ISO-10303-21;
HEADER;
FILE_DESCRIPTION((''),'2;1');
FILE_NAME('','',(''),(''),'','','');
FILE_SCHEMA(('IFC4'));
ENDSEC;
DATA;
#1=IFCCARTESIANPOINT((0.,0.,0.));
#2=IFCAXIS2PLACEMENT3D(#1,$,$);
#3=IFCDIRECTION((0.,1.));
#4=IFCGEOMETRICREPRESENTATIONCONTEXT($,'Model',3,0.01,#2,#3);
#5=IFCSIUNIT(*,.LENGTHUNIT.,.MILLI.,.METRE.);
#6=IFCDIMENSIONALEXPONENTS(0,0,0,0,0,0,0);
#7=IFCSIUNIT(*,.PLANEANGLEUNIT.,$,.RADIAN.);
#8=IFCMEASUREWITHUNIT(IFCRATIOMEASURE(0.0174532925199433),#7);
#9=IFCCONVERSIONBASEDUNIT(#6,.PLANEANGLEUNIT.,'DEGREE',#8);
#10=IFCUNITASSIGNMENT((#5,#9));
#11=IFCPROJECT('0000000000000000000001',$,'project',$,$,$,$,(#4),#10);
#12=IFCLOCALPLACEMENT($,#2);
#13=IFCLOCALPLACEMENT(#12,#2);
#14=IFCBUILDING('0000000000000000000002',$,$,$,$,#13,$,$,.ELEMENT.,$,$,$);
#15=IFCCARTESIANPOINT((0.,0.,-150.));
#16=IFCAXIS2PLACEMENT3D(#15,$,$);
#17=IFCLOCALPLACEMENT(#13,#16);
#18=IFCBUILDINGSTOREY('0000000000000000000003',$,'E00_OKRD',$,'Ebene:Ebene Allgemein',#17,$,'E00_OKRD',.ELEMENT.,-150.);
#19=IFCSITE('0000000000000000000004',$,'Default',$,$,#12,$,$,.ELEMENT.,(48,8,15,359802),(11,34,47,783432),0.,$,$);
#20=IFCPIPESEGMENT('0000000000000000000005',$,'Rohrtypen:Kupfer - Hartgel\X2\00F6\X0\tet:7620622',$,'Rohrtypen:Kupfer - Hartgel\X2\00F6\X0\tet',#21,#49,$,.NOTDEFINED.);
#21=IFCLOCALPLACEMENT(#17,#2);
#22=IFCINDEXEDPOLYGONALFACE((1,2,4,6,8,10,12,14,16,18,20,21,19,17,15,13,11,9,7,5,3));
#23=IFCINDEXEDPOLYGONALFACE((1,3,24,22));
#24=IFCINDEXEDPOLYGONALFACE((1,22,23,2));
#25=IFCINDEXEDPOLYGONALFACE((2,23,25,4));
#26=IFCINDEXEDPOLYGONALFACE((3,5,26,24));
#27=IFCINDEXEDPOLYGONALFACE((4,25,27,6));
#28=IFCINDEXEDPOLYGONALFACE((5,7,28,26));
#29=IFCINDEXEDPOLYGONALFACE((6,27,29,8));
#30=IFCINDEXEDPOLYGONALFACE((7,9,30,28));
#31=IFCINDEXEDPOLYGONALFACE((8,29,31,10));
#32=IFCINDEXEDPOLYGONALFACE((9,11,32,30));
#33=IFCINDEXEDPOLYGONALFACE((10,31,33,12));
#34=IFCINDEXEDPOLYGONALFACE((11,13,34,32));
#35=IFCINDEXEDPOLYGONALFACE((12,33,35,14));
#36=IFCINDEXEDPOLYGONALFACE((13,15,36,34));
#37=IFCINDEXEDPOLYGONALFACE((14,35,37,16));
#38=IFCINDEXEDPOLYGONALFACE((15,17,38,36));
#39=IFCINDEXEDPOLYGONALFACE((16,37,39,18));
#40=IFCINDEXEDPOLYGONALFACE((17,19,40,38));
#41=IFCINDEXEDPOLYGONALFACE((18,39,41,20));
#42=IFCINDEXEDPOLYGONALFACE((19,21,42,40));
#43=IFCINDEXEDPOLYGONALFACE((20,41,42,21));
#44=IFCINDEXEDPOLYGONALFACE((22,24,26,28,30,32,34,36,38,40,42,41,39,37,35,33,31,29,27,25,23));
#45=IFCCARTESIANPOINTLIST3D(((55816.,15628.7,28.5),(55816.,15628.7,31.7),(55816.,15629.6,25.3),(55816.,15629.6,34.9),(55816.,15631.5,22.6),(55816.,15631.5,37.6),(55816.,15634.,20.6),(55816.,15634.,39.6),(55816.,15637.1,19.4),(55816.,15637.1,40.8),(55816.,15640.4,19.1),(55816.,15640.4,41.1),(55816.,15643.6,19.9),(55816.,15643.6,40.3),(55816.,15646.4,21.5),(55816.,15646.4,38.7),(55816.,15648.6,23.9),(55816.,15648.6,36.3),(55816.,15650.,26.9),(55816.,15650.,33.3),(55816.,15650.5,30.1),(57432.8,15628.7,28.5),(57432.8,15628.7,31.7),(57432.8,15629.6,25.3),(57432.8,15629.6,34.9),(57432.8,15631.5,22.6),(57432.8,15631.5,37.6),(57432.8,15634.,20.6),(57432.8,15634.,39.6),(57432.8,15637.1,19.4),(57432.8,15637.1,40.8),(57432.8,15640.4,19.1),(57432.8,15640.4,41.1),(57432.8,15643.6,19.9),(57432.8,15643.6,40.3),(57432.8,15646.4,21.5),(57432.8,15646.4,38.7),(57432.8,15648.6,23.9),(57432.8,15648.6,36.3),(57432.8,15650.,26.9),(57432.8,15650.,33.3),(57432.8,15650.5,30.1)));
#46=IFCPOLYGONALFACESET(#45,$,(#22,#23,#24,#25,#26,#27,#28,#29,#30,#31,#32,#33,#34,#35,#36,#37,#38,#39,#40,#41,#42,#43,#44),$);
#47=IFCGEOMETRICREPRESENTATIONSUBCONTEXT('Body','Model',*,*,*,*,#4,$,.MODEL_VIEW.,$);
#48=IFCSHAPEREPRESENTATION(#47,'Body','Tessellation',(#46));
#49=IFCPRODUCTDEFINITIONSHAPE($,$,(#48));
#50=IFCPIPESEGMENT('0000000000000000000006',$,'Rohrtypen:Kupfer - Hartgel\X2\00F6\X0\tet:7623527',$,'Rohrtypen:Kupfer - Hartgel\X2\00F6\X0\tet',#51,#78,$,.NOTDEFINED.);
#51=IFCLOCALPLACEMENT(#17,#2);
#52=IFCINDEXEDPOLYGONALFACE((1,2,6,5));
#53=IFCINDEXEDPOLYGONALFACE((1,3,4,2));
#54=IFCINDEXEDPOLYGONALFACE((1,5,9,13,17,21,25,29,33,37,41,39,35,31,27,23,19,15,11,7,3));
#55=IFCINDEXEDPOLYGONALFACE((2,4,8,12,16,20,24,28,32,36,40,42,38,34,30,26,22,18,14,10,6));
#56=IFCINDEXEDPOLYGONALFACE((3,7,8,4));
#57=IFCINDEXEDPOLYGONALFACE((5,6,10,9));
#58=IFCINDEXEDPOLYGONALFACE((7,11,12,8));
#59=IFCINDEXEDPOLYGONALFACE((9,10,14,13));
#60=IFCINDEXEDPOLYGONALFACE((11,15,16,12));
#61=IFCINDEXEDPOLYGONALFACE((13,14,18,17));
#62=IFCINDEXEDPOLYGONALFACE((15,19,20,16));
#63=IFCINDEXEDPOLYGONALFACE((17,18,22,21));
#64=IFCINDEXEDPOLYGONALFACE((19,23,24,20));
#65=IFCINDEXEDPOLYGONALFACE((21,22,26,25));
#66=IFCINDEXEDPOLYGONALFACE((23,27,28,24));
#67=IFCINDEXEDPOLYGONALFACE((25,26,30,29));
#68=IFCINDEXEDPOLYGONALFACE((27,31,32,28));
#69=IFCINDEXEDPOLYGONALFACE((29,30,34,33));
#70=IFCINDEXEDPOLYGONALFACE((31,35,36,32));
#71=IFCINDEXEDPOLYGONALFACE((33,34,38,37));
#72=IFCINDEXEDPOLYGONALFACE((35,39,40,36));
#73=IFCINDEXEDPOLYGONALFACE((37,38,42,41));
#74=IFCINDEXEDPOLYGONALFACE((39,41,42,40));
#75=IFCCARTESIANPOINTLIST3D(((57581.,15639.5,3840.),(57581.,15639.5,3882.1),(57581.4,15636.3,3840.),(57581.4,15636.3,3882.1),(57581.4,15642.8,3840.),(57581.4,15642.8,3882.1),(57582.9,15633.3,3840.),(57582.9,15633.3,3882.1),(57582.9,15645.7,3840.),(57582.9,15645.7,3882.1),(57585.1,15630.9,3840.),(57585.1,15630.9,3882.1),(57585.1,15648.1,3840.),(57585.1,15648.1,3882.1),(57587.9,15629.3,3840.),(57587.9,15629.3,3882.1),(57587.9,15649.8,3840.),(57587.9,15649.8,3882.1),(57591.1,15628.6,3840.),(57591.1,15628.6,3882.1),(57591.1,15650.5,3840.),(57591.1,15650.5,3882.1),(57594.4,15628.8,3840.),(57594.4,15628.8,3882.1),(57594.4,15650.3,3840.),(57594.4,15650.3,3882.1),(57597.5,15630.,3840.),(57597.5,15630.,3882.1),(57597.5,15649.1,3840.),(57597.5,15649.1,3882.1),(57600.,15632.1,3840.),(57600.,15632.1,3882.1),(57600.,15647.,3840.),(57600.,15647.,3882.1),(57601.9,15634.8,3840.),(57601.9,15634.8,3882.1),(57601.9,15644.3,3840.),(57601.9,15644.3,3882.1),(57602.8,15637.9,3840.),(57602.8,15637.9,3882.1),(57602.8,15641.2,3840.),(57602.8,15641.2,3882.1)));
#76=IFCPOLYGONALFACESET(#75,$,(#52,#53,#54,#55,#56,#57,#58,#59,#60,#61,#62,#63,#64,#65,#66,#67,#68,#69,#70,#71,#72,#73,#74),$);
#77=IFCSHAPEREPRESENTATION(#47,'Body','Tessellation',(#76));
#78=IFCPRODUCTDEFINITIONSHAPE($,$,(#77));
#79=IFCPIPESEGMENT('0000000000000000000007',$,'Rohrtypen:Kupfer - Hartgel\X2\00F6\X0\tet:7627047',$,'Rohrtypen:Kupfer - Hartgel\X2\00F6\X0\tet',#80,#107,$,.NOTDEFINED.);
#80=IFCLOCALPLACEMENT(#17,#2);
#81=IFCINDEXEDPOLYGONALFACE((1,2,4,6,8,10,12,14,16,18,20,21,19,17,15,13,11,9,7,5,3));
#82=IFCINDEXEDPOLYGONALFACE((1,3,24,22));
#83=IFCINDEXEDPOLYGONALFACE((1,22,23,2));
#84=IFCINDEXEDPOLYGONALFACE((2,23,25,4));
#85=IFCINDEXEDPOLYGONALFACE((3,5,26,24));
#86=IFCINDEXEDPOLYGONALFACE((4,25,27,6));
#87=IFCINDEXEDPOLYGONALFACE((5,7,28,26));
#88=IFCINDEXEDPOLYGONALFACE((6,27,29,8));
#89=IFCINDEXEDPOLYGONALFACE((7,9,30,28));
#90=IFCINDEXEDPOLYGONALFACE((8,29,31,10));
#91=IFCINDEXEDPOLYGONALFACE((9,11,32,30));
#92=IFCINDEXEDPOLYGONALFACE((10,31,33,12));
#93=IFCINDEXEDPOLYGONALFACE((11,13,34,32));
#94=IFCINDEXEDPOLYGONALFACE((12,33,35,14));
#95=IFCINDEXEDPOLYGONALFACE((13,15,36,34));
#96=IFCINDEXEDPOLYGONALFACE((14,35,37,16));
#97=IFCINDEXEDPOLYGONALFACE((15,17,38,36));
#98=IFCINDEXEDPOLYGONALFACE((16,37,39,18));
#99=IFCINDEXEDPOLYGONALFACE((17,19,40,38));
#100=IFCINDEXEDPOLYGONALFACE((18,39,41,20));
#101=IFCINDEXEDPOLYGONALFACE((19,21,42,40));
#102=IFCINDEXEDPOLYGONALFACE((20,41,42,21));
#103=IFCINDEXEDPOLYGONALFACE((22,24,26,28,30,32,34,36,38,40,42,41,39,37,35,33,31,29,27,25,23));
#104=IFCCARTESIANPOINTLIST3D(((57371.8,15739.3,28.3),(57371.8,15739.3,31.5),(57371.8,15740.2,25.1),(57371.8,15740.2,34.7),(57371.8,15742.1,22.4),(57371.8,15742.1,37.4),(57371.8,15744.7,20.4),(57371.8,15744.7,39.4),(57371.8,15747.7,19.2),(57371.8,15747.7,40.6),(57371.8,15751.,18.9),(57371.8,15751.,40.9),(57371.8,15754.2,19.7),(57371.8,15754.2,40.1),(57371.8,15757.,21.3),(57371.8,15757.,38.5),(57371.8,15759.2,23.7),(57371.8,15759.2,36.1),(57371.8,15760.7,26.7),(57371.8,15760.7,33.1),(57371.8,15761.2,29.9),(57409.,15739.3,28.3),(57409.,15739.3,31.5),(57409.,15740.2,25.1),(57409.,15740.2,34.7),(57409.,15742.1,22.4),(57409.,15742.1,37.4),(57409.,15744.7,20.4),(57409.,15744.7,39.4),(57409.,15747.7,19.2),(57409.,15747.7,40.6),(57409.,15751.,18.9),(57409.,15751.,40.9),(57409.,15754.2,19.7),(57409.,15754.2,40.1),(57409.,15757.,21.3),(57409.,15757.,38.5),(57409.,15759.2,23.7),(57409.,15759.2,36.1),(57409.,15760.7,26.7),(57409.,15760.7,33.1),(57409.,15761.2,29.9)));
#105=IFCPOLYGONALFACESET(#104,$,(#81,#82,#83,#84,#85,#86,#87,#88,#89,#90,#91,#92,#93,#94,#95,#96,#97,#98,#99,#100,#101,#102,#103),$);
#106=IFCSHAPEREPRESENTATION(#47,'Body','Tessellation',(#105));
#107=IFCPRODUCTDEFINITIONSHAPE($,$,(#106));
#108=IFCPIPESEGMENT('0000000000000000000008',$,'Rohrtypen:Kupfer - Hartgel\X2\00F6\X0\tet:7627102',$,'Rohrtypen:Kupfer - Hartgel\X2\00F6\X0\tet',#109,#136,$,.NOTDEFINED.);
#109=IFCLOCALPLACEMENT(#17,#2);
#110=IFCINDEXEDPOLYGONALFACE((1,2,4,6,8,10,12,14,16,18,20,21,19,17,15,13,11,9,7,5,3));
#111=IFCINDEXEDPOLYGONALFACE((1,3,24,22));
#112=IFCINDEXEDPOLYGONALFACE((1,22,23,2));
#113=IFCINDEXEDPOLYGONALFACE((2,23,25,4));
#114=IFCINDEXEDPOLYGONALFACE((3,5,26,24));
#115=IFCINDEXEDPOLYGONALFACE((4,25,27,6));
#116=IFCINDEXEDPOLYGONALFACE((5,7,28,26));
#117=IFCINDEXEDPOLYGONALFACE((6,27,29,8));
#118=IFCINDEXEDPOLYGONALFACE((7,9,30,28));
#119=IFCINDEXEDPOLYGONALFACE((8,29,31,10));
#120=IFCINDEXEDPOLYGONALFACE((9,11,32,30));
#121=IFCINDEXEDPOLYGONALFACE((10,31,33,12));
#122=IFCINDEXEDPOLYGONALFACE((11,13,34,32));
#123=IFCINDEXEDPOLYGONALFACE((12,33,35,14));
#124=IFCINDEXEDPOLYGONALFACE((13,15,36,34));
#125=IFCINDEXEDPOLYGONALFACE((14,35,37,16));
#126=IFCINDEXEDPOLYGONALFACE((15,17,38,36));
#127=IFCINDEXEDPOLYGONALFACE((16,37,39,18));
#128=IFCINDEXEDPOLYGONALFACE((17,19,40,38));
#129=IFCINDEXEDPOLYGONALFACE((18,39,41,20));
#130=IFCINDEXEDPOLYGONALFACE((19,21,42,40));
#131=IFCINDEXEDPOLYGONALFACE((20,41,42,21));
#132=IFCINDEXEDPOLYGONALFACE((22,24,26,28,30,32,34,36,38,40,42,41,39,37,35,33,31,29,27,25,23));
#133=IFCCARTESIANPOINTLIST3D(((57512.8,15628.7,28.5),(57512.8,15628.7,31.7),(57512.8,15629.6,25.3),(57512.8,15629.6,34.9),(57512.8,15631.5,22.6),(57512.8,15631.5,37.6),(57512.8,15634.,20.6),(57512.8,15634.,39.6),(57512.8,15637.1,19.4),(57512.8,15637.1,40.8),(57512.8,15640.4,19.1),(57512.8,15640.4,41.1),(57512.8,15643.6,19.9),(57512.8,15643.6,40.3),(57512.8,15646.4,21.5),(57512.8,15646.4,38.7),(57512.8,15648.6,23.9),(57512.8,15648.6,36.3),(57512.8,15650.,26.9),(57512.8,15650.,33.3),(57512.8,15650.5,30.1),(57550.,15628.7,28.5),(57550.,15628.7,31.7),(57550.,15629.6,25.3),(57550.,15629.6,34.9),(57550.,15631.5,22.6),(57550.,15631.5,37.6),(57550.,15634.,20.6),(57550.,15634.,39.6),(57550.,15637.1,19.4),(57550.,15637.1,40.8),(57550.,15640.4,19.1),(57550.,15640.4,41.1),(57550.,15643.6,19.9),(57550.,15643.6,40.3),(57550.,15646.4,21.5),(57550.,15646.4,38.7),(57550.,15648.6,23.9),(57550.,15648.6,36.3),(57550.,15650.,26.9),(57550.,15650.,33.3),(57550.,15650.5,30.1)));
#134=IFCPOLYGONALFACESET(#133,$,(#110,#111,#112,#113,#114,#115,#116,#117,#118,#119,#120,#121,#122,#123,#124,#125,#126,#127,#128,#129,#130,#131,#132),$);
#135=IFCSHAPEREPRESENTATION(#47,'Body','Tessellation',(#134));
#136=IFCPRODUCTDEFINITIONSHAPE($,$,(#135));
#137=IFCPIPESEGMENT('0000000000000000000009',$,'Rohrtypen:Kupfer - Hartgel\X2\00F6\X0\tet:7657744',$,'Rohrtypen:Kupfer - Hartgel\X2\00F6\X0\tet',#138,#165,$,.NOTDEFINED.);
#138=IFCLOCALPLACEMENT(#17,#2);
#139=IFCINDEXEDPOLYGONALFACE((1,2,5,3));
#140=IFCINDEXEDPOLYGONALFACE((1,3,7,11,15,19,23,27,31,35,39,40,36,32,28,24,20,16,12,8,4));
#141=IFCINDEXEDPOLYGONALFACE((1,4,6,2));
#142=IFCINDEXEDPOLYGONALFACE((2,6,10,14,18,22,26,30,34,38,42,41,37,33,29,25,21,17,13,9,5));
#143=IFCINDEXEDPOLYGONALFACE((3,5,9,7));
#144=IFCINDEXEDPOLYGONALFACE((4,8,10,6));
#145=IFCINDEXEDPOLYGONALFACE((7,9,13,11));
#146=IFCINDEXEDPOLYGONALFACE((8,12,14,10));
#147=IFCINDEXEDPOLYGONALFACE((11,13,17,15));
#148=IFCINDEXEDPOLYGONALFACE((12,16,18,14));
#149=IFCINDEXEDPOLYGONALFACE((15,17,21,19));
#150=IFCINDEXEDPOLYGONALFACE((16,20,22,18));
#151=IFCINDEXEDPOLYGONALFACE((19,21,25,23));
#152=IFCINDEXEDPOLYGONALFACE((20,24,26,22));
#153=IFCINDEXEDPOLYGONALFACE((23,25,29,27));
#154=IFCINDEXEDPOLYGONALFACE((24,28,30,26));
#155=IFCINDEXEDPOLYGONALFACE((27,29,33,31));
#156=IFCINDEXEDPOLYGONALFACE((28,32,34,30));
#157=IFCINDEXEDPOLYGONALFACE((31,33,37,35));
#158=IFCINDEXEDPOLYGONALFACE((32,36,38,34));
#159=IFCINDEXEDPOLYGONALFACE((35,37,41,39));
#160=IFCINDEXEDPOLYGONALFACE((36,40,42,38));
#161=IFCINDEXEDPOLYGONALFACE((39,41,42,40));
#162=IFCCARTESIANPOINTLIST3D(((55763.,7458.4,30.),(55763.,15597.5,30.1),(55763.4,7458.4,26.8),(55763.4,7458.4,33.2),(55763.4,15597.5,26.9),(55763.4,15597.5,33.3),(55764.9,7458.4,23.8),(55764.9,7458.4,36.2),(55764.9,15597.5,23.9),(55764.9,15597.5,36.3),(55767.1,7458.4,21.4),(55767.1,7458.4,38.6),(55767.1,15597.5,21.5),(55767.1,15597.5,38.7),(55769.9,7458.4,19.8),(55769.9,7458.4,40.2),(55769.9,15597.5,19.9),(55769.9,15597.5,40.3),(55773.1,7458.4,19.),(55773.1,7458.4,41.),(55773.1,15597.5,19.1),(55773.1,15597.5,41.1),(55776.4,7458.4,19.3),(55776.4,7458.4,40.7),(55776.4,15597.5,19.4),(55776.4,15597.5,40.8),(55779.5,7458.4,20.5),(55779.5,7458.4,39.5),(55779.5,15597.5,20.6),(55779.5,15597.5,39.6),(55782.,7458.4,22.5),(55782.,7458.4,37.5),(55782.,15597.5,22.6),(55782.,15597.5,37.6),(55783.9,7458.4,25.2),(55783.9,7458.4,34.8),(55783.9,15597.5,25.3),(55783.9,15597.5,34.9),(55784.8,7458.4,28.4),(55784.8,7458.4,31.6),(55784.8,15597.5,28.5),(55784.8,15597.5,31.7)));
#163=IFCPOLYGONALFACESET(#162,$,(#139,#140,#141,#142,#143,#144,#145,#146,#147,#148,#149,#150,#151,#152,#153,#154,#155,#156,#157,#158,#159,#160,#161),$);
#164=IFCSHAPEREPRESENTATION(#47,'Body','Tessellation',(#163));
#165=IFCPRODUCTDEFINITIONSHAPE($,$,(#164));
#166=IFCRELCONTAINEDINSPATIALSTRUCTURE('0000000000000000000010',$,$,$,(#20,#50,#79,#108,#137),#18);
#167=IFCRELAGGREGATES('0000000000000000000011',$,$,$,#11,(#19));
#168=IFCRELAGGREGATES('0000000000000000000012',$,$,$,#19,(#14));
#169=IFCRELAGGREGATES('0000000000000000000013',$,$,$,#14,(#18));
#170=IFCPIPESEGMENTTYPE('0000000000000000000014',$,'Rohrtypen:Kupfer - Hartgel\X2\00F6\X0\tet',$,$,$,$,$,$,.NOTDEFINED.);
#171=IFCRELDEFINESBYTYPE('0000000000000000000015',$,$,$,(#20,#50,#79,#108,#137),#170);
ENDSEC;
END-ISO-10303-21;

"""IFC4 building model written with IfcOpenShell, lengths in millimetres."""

from ifc_helpers import new_model, entity, si_unit, converted_unit, direction, frame, frame_2d, origin, origin_2d_with_axis, place, context, subcontext, project, spatial, circle, extrude, type_object, element, save


model = new_model("IFC4")

# Units and contexts
model_context = context("Model", 3, precision=0.01, world=origin(), true_north=direction((0.0, 1.0)))
body_context = subcontext(model_context, "Body", "Model", "MODEL_VIEW")
ifc_project = project(units=[si_unit("LENGTHUNIT", "METRE", prefix="MILLI"), converted_unit("PLANEANGLEUNIT", "DEGREE", entity("IfcRatioMeasure", 0.0174532925199433), si_unit("PLANEANGLEUNIT", "RADIAN"), dimensions=[0, 0, 0, 0, 0, 0, 0])], contexts=[model_context])

# Site, building, storey
site_placement = place(None, origin())
site = spatial("IfcSite", under=ifc_project, at=site_placement, Name="Default", CompositionType="ELEMENT", RefLatitude=(48, 8, 15, 359802), RefLongitude=(11, 34, 47, 783432), RefElevation=0.0)
building_placement = place(site_placement, origin())
building = spatial("IfcBuilding", under=site, at=building_placement, CompositionType="ELEMENT")
storey_placement = place(building_placement, frame((0.0, 0.0, -150.0)))
storey = spatial("IfcBuildingStorey", under=building, at=storey_placement, Name="E00_OKRD", ObjectType="Ebene:Ebene Allgemein", LongName="E00_OKRD", CompositionType="ELEMENT", Elevation=-150.0)

# Pipe segments
pipe_segment_type = type_object("IfcPipeSegmentType", Name="Rohrtypen:Kupfer - Hartgelötet", PredefinedType="NOTDEFINED")
pipe_segment_1_placement = place(storey_placement, frame((55816.0, 15626.9, 17.5)))
element("IfcPipeSegment", 1, at=pipe_segment_1_placement, inside=storey, type_object=pipe_segment_type, Name="Rohrtypen:Kupfer - Hartgelötet:7620622", ObjectType="Rohrtypen:Kupfer - Hartgelötet", PredefinedType="NOTDEFINED", context=body_context, shape_type="SweptSolid", body=[
    extrude(circle(Radius=11.0, at=origin_2d_with_axis()), frame((0.0, 12.6, 12.6), z_axis=(1.0, 0.0, 0.0), x_axis=(0.0, 1.0, 0.0)), (0.0, 0.0, 1.0), 1616.9),
])
pipe_segment_2_placement = place(storey_placement, frame((57579.4, 15626.9, 3840.0)))
element("IfcPipeSegment", 2, at=pipe_segment_2_placement, inside=storey, type_object=pipe_segment_type, Name="Rohrtypen:Kupfer - Hartgelötet:7623527", ObjectType="Rohrtypen:Kupfer - Hartgelötet", PredefinedType="NOTDEFINED", context=body_context, shape_type="SweptSolid", body=[
    extrude(circle(Radius=11.0, at=frame_2d((0.0, 0.0), x_axis=(1.0, 0.0))), frame((12.6, 12.6, 0.0), z_axis=(0.000002, 0.0, 1.0), x_axis=(-1.0, 0.0, 0.000002)), (0.0, 0.0, 1.0), 42.1),
])
pipe_segment_3_placement = place(storey_placement, frame((57371.8, 15737.6, 17.3)))
element("IfcPipeSegment", 3, at=pipe_segment_3_placement, inside=storey, type_object=pipe_segment_type, Name="Rohrtypen:Kupfer - Hartgelötet:7627047", ObjectType="Rohrtypen:Kupfer - Hartgelötet", PredefinedType="NOTDEFINED", context=body_context, shape_type="SweptSolid", body=[
    extrude(circle(Radius=11.0, at=origin_2d_with_axis()), frame((0.0, 12.6, 12.6), z_axis=(1.0, 0.0, 0.0), x_axis=(0.0, 1.0, 0.0)), (0.0, 0.0, 1.0), 37.1),
])
pipe_segment_4_placement = place(storey_placement, frame((57512.8, 15626.9, 17.5)))
element("IfcPipeSegment", 4, at=pipe_segment_4_placement, inside=storey, type_object=pipe_segment_type, Name="Rohrtypen:Kupfer - Hartgelötet:7627102", ObjectType="Rohrtypen:Kupfer - Hartgelötet", PredefinedType="NOTDEFINED", context=body_context, shape_type="SweptSolid", body=[
    extrude(circle(Radius=11.0, at=origin_2d_with_axis()), frame((0.0, 12.6, 12.6), z_axis=(1.0, 0.0, 0.0), x_axis=(0.0, 1.0, 0.0)), (0.0, 0.0, 1.0), 37.1),
])
pipe_segment_5_placement = place(storey_placement, frame((55761.4, 7458.4, 17.4)))
element("IfcPipeSegment", 5, at=pipe_segment_5_placement, inside=storey, type_object=pipe_segment_type, Name="Rohrtypen:Kupfer - Hartgelötet:7657744", ObjectType="Rohrtypen:Kupfer - Hartgelötet", PredefinedType="NOTDEFINED", context=body_context, shape_type="SweptSolid", body=[
    extrude(circle(Radius=11.0, at=frame_2d((0.0, 0.0), x_axis=(1.0, 0.0))), frame((12.6, 0.0, 12.6), z_axis=(0.0, 1.0, 0.000012), x_axis=(-1.0, 0.0, 0.0)), (0.0, 0.0, 1.0), 8139.1),
])

save(model, "model.ifc")
